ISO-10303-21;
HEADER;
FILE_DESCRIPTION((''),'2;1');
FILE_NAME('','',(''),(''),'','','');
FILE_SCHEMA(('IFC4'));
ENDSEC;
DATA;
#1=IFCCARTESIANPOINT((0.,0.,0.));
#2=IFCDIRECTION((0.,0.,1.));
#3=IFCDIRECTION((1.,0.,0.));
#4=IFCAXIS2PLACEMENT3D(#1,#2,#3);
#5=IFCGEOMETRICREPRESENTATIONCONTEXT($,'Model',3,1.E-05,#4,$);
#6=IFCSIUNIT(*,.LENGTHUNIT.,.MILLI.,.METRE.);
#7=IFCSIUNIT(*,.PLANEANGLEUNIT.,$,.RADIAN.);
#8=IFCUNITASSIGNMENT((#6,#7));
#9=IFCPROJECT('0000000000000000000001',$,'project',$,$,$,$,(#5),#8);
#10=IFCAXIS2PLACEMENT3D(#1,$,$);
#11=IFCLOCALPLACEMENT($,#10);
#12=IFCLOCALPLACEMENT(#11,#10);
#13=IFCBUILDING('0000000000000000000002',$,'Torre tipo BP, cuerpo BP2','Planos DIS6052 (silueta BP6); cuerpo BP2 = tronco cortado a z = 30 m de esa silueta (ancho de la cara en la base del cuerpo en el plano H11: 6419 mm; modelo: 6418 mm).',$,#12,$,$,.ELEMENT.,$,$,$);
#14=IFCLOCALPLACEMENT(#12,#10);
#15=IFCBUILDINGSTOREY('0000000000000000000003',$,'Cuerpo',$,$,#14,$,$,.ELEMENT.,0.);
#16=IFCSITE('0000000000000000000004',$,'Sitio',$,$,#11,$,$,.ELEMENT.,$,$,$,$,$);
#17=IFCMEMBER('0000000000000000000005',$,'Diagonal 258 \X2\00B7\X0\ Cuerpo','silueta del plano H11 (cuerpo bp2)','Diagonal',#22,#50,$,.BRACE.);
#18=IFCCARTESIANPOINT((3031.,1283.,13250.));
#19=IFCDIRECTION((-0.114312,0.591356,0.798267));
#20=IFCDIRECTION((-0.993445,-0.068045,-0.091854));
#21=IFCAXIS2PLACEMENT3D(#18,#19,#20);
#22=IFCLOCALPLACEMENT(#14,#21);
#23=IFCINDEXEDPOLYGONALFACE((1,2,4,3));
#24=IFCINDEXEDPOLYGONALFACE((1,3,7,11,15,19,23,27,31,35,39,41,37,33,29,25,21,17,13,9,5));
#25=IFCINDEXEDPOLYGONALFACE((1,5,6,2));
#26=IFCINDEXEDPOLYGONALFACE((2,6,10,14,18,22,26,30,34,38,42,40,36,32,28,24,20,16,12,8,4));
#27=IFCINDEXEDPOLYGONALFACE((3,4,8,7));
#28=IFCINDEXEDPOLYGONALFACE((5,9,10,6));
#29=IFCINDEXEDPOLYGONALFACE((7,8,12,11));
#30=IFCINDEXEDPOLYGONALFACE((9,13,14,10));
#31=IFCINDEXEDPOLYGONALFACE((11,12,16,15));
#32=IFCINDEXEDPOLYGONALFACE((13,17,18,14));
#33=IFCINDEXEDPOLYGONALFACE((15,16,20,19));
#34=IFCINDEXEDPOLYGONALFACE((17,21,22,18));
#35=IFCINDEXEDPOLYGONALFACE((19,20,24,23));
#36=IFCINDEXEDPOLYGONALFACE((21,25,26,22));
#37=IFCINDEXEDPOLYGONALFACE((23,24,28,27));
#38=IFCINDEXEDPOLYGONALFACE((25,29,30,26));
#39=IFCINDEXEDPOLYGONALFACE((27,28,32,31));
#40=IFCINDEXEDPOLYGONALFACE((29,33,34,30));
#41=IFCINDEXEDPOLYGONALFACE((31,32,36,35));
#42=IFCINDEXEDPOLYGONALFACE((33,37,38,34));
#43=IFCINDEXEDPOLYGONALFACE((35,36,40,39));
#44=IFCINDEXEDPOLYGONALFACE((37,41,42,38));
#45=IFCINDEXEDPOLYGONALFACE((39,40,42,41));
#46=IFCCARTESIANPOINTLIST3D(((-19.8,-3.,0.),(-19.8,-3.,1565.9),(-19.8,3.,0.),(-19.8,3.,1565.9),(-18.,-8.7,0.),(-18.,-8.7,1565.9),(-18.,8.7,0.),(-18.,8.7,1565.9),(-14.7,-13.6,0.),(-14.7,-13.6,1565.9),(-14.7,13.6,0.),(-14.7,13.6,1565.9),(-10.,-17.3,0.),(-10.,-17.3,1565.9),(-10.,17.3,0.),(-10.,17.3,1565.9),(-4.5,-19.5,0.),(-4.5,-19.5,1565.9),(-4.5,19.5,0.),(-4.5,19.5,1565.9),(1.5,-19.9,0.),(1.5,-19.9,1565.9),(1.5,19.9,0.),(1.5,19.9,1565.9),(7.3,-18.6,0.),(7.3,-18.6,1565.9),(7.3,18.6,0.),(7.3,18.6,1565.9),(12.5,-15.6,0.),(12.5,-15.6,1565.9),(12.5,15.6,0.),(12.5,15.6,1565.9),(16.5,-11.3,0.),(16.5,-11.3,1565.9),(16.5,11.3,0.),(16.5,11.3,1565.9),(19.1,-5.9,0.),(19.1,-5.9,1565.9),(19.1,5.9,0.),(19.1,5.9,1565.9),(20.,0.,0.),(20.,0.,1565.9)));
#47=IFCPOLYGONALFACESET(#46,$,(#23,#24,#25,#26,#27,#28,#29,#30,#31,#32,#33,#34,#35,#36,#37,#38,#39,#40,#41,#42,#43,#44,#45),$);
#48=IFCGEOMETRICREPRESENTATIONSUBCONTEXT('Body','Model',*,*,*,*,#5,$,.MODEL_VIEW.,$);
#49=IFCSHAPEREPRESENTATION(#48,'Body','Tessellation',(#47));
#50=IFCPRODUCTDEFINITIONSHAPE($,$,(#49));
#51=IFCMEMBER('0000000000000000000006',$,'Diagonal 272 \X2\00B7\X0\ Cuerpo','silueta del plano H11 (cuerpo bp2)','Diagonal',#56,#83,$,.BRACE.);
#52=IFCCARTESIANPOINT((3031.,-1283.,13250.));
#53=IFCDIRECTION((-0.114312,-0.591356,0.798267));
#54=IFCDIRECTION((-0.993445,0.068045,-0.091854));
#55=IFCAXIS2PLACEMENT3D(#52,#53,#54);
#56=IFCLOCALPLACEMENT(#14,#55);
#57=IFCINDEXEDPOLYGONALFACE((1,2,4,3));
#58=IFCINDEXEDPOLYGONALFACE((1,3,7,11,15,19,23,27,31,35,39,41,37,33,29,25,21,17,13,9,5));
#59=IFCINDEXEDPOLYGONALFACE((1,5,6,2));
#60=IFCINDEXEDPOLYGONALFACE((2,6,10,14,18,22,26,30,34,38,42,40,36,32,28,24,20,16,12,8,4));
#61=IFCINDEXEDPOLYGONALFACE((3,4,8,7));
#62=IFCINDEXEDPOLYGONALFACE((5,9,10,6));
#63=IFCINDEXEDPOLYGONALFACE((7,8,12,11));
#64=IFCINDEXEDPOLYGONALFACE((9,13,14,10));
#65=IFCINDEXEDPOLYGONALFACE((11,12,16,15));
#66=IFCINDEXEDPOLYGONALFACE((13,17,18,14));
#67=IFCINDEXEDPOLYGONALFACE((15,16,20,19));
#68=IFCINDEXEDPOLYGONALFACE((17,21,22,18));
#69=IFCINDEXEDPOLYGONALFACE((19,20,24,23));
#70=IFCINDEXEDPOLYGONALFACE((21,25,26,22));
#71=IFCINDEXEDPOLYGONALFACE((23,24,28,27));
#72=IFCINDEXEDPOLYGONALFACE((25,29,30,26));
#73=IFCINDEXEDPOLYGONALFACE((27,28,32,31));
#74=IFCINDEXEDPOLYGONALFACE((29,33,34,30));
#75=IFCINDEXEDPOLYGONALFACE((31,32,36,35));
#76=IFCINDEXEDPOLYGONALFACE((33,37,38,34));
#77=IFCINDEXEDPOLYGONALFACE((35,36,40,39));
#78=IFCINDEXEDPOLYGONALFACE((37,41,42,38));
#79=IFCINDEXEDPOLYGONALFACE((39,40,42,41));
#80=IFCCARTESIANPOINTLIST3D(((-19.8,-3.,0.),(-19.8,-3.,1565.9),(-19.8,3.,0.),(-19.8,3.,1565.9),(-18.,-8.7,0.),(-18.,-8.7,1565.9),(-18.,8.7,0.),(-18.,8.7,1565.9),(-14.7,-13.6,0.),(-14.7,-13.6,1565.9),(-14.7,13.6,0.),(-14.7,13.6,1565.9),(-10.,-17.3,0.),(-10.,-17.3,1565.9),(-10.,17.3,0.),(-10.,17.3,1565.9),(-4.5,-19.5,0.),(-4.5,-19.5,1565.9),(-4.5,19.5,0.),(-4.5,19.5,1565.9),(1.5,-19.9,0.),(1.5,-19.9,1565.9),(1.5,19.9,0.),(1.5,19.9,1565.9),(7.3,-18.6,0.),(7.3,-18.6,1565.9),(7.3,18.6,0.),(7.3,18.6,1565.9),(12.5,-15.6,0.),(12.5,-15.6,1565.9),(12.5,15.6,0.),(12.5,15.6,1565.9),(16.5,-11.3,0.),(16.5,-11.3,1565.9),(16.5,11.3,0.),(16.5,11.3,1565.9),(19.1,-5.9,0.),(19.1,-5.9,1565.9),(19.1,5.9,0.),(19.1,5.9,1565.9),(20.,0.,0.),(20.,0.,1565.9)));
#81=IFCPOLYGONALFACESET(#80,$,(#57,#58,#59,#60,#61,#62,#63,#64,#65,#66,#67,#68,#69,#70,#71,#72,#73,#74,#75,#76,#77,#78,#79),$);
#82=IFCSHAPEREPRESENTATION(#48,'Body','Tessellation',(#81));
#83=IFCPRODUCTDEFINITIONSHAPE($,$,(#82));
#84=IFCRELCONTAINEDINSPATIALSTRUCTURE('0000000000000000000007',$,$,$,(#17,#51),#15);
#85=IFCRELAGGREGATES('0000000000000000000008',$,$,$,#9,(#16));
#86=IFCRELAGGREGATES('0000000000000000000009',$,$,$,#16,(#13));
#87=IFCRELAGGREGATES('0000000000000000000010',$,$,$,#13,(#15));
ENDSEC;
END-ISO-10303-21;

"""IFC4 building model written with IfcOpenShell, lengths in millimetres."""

from ifc_helpers import new_model, si_unit, frame, origin, origin_with_axes, place, context, subcontext, project, spatial, circle, extrude, element, save


model = new_model("IFC4")

# Units and contexts
model_context = context("Model", 3, precision=1e-05, world=origin_with_axes())
body_context = subcontext(model_context, "Body", "Model", "MODEL_VIEW")
ifc_project = project(units=[si_unit("LENGTHUNIT", "METRE", prefix="MILLI"), si_unit("PLANEANGLEUNIT", "RADIAN")], contexts=[model_context])

# Site, building, storey
site_placement = place(None, origin())
site = spatial("IfcSite", under=ifc_project, at=site_placement, Name="Sitio", CompositionType="ELEMENT")
building_placement = place(site_placement, origin())
building = spatial("IfcBuilding", under=site, at=building_placement, Name="Torre tipo BP, cuerpo BP2", Description="Planos DIS6052 (silueta BP6); cuerpo BP2 = tronco cortado a z = 30 m de esa silueta (ancho de la cara en la base del cuerpo en el plano H11: 6419 mm; modelo: 6418 mm).", CompositionType="ELEMENT")
storey_placement = place(building_placement, origin())
storey = spatial("IfcBuildingStorey", under=building, at=storey_placement, Name="Cuerpo", CompositionType="ELEMENT", Elevation=0.0)

# Members
member_1_placement = place(storey_placement, frame((3031.0, 1283.0, 13250.0), z_axis=(-0.114312, 0.591356, 0.798267), x_axis=(-0.993445, -0.068045, -0.091854)))
element("IfcMember", 1, at=member_1_placement, inside=storey, Name="Diagonal 258 · Cuerpo", Description="silueta del plano H11 (cuerpo bp2)", ObjectType="Diagonal", PredefinedType="BRACE", context=body_context, shape_type="SweptSolid", body=[
    extrude(circle(Radius=20.0), None, (0.0, 0.0, 1.0), 1565.9),
])
member_2_placement = place(storey_placement, frame((3031.0, -1283.0, 13250.0), z_axis=(-0.114312, -0.591356, 0.798267), x_axis=(-0.993445, 0.068045, -0.091854)))
element("IfcMember", 2, at=member_2_placement, inside=storey, Name="Diagonal 272 · Cuerpo", Description="silueta del plano H11 (cuerpo bp2)", ObjectType="Diagonal", PredefinedType="BRACE", context=body_context, shape_type="SweptSolid", body=[
    extrude(circle(Radius=20.0), None, (0.0, 0.0, 1.0), 1565.9),
])

save(model, "model.ifc")
